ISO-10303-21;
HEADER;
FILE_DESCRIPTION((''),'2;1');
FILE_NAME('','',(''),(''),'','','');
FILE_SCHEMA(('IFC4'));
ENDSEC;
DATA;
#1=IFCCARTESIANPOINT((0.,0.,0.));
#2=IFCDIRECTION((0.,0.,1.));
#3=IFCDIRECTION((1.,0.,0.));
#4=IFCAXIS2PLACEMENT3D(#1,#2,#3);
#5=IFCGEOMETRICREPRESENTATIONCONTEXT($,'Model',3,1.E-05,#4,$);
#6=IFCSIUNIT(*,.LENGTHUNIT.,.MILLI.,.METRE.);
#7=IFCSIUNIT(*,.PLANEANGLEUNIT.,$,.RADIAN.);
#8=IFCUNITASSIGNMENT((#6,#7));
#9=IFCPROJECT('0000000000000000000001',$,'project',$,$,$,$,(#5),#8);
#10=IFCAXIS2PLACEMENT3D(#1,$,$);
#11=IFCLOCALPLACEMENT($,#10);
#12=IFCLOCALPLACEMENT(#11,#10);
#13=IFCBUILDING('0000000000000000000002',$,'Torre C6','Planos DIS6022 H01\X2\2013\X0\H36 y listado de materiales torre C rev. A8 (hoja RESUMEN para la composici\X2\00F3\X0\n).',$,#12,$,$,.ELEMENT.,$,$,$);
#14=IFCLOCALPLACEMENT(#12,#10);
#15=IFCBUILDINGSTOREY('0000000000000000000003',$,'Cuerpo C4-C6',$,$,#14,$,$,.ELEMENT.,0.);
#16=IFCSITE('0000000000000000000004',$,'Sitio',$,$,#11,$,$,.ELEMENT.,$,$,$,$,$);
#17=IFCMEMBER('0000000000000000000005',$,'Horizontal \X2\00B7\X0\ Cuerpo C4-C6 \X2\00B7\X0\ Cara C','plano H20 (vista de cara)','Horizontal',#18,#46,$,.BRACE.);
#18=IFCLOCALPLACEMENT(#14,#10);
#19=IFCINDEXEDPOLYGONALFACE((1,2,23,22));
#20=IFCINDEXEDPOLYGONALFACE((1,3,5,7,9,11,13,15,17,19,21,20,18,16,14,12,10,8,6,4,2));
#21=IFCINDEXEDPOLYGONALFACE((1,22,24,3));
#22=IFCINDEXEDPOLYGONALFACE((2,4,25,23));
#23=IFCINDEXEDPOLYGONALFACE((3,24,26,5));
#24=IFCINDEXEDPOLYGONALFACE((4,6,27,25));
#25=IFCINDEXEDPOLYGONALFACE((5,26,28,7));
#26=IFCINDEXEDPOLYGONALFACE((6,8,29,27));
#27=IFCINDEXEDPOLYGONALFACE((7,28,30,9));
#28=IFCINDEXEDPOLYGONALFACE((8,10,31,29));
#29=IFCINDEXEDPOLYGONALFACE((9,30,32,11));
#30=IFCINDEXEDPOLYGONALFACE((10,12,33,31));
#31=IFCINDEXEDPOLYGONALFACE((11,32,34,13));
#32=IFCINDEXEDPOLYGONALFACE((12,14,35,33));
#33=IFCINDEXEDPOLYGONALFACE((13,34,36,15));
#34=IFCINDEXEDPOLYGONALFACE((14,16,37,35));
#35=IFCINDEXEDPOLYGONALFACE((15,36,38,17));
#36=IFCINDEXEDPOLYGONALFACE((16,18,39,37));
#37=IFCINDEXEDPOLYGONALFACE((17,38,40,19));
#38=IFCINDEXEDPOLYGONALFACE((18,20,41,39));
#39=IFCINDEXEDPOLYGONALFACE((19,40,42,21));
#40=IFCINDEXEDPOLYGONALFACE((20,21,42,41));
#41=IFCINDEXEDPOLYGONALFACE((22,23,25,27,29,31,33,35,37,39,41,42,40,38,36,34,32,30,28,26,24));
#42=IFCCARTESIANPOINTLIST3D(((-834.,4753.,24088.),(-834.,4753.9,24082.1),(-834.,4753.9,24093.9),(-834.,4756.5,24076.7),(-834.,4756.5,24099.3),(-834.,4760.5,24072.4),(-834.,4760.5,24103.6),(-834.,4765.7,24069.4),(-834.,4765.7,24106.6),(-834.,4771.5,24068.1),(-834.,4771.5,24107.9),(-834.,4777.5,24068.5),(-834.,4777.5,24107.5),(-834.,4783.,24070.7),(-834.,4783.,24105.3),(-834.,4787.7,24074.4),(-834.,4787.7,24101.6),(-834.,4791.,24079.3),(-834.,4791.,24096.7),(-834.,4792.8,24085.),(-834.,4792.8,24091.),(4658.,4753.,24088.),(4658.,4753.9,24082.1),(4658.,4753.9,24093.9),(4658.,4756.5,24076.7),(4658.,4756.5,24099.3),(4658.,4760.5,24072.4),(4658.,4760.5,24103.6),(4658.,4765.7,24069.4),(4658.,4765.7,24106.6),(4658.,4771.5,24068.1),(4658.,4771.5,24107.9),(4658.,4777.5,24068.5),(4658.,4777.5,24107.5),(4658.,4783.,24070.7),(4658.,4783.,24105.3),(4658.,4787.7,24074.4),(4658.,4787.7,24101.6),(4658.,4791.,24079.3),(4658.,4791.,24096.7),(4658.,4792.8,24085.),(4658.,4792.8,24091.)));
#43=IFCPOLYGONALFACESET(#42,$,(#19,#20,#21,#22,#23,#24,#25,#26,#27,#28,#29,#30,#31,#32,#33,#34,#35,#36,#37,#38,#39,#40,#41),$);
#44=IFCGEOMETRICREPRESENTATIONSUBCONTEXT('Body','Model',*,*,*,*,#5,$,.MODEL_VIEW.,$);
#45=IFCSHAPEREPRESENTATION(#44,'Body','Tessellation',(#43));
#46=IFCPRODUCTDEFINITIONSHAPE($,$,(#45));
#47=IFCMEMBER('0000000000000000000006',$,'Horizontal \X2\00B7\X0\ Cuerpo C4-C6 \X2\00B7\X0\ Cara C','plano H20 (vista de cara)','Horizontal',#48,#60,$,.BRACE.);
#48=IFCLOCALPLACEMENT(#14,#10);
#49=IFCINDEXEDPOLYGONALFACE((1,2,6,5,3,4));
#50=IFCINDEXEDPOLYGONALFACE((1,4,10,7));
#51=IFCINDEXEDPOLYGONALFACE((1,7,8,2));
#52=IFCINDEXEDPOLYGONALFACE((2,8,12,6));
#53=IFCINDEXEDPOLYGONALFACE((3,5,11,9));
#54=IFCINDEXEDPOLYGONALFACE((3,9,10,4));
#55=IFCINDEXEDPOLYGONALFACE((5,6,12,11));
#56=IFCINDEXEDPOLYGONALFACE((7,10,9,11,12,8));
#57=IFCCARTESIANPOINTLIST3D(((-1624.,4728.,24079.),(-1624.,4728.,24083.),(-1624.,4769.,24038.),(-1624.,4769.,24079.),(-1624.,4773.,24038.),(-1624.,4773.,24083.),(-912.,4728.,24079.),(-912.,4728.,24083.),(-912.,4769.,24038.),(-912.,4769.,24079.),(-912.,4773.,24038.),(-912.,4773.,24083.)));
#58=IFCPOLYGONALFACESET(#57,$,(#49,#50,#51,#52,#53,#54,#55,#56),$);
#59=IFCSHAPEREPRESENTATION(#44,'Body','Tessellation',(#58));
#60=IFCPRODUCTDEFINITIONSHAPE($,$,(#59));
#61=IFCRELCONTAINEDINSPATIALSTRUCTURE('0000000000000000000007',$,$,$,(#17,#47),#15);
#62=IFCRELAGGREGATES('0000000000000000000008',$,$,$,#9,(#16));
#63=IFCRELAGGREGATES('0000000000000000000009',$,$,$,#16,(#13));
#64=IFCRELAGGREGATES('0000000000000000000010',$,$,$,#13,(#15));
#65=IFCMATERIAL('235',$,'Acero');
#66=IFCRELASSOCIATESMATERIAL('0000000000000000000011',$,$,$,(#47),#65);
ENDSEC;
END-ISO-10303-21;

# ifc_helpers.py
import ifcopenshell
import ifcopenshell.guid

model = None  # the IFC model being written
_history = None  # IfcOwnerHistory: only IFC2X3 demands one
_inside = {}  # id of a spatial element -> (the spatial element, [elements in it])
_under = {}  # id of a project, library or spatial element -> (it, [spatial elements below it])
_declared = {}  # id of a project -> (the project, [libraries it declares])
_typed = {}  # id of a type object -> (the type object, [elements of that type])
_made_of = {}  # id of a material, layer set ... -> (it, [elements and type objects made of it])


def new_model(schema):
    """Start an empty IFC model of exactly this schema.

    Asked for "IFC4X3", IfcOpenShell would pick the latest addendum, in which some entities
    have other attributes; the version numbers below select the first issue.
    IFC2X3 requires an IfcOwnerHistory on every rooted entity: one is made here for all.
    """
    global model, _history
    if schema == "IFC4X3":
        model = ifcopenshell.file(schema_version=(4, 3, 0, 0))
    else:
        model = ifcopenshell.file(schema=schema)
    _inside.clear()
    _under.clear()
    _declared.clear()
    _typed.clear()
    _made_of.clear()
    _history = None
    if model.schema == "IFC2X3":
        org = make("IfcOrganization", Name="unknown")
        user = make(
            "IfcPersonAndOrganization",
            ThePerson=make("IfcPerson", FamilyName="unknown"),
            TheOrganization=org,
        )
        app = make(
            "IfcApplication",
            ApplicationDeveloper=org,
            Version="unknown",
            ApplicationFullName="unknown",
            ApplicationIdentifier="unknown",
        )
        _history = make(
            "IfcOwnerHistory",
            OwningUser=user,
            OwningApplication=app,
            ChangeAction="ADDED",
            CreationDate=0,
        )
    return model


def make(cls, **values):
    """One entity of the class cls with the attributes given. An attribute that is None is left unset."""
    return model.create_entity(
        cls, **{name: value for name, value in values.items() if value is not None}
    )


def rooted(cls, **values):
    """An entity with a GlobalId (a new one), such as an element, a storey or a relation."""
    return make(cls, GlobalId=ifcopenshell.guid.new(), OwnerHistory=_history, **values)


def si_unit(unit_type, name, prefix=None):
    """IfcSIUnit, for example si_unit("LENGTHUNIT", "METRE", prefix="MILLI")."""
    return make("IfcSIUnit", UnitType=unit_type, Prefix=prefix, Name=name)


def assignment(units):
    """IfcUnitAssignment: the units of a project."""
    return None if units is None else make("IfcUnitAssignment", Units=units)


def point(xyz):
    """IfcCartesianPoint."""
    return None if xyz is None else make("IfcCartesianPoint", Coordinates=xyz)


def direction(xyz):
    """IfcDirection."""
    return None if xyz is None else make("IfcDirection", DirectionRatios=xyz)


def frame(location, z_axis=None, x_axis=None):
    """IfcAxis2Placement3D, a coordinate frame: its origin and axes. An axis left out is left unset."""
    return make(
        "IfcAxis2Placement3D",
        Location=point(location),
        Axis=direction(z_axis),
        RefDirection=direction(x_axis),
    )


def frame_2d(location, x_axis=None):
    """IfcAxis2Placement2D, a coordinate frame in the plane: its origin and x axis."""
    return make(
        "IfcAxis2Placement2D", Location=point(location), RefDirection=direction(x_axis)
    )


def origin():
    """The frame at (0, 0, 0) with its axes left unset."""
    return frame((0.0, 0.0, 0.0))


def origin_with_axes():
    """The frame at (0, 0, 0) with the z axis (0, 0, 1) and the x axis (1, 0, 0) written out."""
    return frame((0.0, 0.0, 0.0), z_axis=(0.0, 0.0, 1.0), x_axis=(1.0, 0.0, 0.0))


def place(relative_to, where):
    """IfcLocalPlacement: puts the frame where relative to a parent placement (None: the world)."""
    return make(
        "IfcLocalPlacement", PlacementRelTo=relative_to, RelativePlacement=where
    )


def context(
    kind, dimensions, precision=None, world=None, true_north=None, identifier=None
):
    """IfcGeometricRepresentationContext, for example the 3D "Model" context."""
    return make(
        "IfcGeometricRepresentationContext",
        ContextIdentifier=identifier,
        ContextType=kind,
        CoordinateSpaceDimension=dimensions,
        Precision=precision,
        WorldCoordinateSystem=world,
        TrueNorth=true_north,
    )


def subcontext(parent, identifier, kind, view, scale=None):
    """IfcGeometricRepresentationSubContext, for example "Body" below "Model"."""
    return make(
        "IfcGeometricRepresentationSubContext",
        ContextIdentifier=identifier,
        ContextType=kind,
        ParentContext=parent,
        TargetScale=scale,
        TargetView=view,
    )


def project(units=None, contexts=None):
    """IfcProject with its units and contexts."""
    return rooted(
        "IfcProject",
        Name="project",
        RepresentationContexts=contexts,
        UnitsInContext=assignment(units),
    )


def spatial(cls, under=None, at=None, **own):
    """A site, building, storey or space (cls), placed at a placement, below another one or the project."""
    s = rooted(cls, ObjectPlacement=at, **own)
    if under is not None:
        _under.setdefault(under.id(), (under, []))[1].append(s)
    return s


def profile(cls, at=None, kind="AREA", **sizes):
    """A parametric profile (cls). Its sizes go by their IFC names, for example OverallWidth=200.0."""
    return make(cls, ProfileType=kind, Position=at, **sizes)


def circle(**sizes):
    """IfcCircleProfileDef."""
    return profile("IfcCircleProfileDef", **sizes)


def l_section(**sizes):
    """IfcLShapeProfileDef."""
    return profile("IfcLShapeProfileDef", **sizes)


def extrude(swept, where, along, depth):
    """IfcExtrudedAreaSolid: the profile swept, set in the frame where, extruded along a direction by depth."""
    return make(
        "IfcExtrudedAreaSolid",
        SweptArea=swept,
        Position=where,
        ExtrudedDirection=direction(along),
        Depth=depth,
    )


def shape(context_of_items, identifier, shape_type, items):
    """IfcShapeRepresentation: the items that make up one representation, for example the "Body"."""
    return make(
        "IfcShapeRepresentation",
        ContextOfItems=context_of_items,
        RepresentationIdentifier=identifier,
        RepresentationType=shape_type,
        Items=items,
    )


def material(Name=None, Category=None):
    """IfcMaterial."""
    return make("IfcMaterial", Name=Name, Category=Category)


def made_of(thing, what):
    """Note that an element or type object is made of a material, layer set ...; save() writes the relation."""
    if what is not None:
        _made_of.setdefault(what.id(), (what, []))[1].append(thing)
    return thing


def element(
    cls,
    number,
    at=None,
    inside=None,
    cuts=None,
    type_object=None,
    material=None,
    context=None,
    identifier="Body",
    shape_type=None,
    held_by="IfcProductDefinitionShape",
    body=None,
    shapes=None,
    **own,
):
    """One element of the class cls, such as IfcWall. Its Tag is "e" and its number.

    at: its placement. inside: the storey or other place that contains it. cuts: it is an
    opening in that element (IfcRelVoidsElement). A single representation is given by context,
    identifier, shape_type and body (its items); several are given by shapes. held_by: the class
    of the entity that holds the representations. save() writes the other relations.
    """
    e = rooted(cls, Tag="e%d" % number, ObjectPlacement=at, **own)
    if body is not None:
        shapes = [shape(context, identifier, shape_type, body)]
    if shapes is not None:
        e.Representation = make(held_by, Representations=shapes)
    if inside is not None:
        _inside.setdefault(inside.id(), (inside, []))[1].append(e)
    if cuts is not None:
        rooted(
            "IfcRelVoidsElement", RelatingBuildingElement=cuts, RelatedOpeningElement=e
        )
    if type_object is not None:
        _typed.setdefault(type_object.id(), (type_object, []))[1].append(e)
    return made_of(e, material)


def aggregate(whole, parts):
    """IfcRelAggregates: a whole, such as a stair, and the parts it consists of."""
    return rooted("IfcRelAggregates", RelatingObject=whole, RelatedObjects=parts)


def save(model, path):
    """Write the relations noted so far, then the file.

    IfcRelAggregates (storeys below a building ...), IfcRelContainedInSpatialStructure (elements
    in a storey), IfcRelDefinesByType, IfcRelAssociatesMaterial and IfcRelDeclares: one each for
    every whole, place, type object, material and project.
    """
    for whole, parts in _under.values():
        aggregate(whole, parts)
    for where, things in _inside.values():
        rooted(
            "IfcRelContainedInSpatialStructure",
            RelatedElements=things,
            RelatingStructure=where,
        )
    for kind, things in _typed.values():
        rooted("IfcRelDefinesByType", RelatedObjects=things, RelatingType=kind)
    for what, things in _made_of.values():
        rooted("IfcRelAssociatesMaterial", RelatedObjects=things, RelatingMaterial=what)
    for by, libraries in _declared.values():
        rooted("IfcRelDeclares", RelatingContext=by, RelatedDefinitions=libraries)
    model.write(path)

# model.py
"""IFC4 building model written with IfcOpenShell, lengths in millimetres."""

from ifc_helpers import new_model, si_unit, frame, frame_2d, origin, origin_with_axes, place, context, subcontext, project, spatial, circle, l_section, extrude, material, element, save


model = new_model("IFC4")

# Units and contexts
model_context = context("Model", 3, precision=1e-05, world=origin_with_axes())
body_context = subcontext(model_context, "Body", "Model", "MODEL_VIEW")
ifc_project = project(units=[si_unit("LENGTHUNIT", "METRE", prefix="MILLI"), si_unit("PLANEANGLEUNIT", "RADIAN")], contexts=[model_context])

# Site, building, storey
site_placement = place(None, origin())
site = spatial("IfcSite", under=ifc_project, at=site_placement, Name="Sitio", CompositionType="ELEMENT")
building_placement = place(site_placement, origin())
building = spatial("IfcBuilding", under=site, at=building_placement, Name="Torre C6", Description="Planos DIS6022 H01–H36 y listado de materiales torre C rev. A8 (hoja RESUMEN para la composición).", CompositionType="ELEMENT")
storey_placement = place(building_placement, origin())
storey = spatial("IfcBuildingStorey", under=building, at=storey_placement, Name="Cuerpo C4-C6", CompositionType="ELEMENT", Elevation=0.0)

# Members
ifc_material_1 = material(Name="235", Category="Acero")
member_1_placement = place(storey_placement, frame((-834.0, 4773.0, 24088.0), z_axis=(1.0, 0.0, 0.0), x_axis=(0.0, -1.0, 0.0)))
element("IfcMember", 1, at=member_1_placement, inside=storey, Name="Horizontal · Cuerpo C4-C6 · Cara C", Description="plano H20 (vista de cara)", ObjectType="Horizontal", PredefinedType="BRACE", context=body_context, shape_type="SweptSolid", body=[
    extrude(circle(Radius=20.0), None, (0.0, 0.0, 1.0), 5492.0),
])
member_2_placement = place(storey_placement, frame((-1624.0, 4773.0, 24083.0), z_axis=(1.0, 0.0, 0.0), x_axis=(0.0, -1.0, 0.0)))
element("IfcMember", 2, at=member_2_placement, inside=storey, material=ifc_material_1, Name="Horizontal · Cuerpo C4-C6 · Cara C", Description="plano H20 (vista de cara)", ObjectType="Horizontal", PredefinedType="BRACE", context=body_context, shape_type="SweptSolid", body=[
    extrude(l_section(Depth=45.0, Width=45.0, Thickness=4.0, at=frame_2d((22.5, 22.5))), None, (0.0, 0.0, 1.0), 712.0),
])

save(model, "model.ifc")
